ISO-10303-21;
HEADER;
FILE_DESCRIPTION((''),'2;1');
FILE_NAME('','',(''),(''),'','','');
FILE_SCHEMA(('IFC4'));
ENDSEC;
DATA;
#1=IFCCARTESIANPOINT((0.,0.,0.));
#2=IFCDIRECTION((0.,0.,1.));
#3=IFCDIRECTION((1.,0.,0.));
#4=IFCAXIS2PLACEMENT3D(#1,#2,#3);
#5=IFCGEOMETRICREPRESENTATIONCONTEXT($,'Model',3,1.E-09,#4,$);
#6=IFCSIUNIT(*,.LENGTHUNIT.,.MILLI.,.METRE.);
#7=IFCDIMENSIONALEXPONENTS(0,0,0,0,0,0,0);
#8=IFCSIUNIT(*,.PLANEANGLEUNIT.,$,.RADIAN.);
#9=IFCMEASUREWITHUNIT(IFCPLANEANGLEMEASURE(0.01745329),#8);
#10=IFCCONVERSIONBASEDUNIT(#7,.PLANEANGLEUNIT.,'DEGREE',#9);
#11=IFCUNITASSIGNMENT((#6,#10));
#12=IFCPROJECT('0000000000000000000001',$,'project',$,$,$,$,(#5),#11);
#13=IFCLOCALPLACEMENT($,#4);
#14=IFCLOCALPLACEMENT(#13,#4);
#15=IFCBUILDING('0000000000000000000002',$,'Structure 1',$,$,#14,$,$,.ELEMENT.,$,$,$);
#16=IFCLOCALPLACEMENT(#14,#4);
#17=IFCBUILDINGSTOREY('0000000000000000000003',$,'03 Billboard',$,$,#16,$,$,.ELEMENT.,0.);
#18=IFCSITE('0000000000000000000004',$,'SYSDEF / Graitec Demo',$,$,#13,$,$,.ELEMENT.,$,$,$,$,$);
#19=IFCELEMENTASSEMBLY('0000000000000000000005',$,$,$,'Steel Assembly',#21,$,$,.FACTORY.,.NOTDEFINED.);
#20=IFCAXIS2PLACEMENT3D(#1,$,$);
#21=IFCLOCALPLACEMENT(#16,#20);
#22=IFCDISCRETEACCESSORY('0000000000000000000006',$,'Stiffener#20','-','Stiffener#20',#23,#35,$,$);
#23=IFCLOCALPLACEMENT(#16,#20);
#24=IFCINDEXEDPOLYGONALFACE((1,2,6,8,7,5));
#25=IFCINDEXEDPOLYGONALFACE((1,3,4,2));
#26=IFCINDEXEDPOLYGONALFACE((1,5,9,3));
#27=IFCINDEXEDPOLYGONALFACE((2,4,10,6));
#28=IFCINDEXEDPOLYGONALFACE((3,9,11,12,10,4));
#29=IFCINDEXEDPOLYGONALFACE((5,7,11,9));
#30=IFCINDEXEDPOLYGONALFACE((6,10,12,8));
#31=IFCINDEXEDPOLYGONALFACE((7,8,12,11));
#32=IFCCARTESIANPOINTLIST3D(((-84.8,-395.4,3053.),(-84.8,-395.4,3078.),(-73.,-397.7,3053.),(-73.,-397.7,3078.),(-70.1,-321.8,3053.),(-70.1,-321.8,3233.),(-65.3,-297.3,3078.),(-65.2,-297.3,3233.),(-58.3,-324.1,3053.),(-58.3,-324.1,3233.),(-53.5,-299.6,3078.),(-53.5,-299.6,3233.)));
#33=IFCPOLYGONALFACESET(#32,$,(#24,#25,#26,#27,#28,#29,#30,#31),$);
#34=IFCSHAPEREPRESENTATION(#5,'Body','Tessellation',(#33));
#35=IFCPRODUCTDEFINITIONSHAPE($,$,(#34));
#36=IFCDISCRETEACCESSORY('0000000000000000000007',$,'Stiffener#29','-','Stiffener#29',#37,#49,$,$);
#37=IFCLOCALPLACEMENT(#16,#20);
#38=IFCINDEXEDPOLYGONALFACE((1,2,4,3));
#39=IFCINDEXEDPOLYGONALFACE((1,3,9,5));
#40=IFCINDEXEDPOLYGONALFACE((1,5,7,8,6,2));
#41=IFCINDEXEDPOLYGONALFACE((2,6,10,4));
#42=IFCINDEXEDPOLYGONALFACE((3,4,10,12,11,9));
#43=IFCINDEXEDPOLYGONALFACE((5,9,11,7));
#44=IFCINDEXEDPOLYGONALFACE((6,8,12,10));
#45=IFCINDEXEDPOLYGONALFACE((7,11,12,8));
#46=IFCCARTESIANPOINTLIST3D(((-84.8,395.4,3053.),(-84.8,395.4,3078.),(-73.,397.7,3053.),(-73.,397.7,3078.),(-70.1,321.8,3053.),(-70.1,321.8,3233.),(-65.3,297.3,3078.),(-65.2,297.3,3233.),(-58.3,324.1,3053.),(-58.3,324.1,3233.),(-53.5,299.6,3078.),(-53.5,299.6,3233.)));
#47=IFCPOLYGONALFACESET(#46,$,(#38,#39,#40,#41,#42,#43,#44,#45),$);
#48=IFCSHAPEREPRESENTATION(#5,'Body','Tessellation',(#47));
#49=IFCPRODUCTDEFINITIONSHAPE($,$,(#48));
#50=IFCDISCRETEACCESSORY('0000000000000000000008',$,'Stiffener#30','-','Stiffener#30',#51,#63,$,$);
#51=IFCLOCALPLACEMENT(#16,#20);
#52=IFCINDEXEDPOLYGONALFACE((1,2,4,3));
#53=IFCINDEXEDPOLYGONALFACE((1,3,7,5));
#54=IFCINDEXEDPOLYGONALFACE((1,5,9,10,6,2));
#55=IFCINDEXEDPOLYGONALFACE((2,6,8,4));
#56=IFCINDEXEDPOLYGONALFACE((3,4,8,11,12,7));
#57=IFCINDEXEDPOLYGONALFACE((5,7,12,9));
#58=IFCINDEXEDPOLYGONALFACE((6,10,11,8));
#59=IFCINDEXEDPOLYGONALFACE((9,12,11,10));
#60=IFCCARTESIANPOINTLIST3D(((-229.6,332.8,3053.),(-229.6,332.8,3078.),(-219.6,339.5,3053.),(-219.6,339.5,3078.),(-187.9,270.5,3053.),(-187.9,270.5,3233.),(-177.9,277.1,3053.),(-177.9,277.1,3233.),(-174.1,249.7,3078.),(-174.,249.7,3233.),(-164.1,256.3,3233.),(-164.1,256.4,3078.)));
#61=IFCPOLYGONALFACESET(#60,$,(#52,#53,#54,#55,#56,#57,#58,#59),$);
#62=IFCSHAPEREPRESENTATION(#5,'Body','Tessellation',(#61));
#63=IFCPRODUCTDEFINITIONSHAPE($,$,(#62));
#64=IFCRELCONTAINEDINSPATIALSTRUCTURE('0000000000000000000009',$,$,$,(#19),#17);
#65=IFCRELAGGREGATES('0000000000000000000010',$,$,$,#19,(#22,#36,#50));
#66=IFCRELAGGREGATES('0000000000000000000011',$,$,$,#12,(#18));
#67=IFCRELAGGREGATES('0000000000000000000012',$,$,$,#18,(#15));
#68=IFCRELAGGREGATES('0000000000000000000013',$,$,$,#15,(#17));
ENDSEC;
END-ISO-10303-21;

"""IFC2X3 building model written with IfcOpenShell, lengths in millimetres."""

from ifc_helpers import new_model, entity, si_unit, converted_unit, frame, origin, origin_with_axes, place, context, project, spatial, polyline, outline, extrude, element, aggregate, save


model = new_model("IFC2X3")

# Units and contexts
model_context = context("Model", 3, precision=1e-09, world=origin_with_axes())
ifc_project = project(units=[si_unit("LENGTHUNIT", "METRE", prefix="MILLI"), converted_unit("PLANEANGLEUNIT", "DEGREE", entity("IfcPlaneAngleMeasure", 0.01745329), si_unit("PLANEANGLEUNIT", "RADIAN"), dimensions=[0, 0, 0, 0, 0, 0, 0])], contexts=[model_context])

# Site, building, storey
site_placement = place(None, origin_with_axes())
site = spatial("IfcSite", under=ifc_project, at=site_placement, Name="SYSDEF / Graitec Demo", CompositionType="ELEMENT")
building_placement = place(site_placement, origin_with_axes())
building = spatial("IfcBuilding", under=site, at=building_placement, Name="Structure 1", CompositionType="ELEMENT")
storey_placement = place(building_placement, origin_with_axes())
storey = spatial("IfcBuildingStorey", under=building, at=storey_placement, Name="03 Billboard", CompositionType="ELEMENT", Elevation=0.0)

# Element assembly, discrete accessories, openings
assembly_placement = place(None, frame((-4406.3, 0.0, 3558.0), z_axis=(-1.0, 0.0, 0.0), x_axis=(0.0, -1.0, 0.0)))
assembly = element("IfcElementAssembly", 1, at=assembly_placement, inside=storey, ObjectType="Steel Assembly", AssemblyPlace="FACTORY", PredefinedType="NOTDEFINED")
discrete_accessory_1_placement = place(assembly_placement, frame((297.3, -505.0, -4341.1), z_axis=(0.19509, 0.0, -0.980785), x_axis=(0.0, 1.0, 0.0)))
discrete_accessory_1 = element("IfcDiscreteAccessory", 2, at=discrete_accessory_1_placement, Name="Stiffener#20", Description="-", ObjectType="Stiffener#20", context=model_context, shape_type="SweptSolid", body=[
    extrude(outline(polyline([(0.0, 0.0), (180.0, 0.0), (180.0, 100.0), (0.0, 100.0), (0.0, 0.0)])), origin_with_axes(), (0.0, 0.0, 1.0), 12.0),
])
opening_1_placement = place(discrete_accessory_1_placement, frame((0.0, 0.0, 0.0), z_axis=(0.0, 0.0, 1.0), x_axis=(1.0, 0.0, 0.0)))
element("IfcOpeningElement", 3, at=opening_1_placement, cuts=discrete_accessory_1, ObjectType="Opening", context=model_context, shape_type="SweptSolid", body=[
    extrude(outline(polyline([(180.0, 100.0), (25.0, 100.0), (180.0, 25.0), (180.0, 100.0)])), origin(), (0.0, 0.0, 1.0), 12.0),
])
opening_2_placement = place(discrete_accessory_1_placement, frame((0.0, 0.0, 0.0), z_axis=(0.0, 0.0, 1.0), x_axis=(1.0, 0.0, 0.0)))
element("IfcOpeningElement", 4, at=opening_2_placement, cuts=discrete_accessory_1, ObjectType="Opening", context=model_context, shape_type="SweptSolid", body=[
    extrude(outline(polyline([(0.0, 0.0), (25.0, 0.0), (0.0, 25.0), (0.0, 0.0)])), origin(), (0.0, 0.0, 1.0), 12.0),
])
discrete_accessory_2_placement = place(assembly_placement, frame((-299.6, -505.0, -4352.9), z_axis=(0.19509, 0.0, 0.980785), x_axis=(0.0, 1.0, 0.0)))
discrete_accessory_2 = element("IfcDiscreteAccessory", 5, at=discrete_accessory_2_placement, Name="Stiffener#29", Description="-", ObjectType="Stiffener#29", context=model_context, shape_type="SweptSolid", body=[
    extrude(outline(polyline([(0.0, 0.0), (180.0, 0.0), (180.0, 100.0), (0.0, 100.0), (0.0, 0.0)])), origin_with_axes(), (0.0, 0.0, 1.0), 12.0),
])
opening_3_placement = place(discrete_accessory_2_placement, frame((0.0, 0.0, 0.0), z_axis=(0.0, 0.0, 1.0), x_axis=(1.0, 0.0, 0.0)))
element("IfcOpeningElement", 6, at=opening_3_placement, cuts=discrete_accessory_2, ObjectType="Opening", context=model_context, shape_type="SweptSolid", body=[
    extrude(outline(polyline([(180.0, 100.0), (25.0, 100.0), (180.0, 25.0), (180.0, 100.0)])), origin(), (0.0, 0.0, 1.0), 12.0),
])
opening_4_placement = place(discrete_accessory_2_placement, frame((0.0, 0.0, 0.0), z_axis=(0.0, 0.0, 1.0), x_axis=(1.0, 0.0, 0.0)))
element("IfcOpeningElement", 7, at=opening_4_placement, cuts=discrete_accessory_2, ObjectType="Opening", context=model_context, shape_type="SweptSolid", body=[
    extrude(outline(polyline([(0.0, 0.0), (25.0, 0.0), (0.0, 25.0), (0.0, 0.0)])), origin(), (0.0, 0.0, 1.0), 12.0),
])
discrete_accessory_3_placement = place(assembly_placement, frame((-256.3, -505.0, -4242.3), z_axis=(0.55557, 0.0, 0.83147), x_axis=(0.0, 1.0, 0.0)))
discrete_accessory_3 = element("IfcDiscreteAccessory", 8, at=discrete_accessory_3_placement, Name="Stiffener#30", Description="-", ObjectType="Stiffener#30", context=model_context, shape_type="SweptSolid", body=[
    extrude(outline(polyline([(0.0, 0.0), (180.0, 0.0), (180.0, 100.0), (0.0, 100.0), (0.0, 0.0)])), origin_with_axes(), (0.0, 0.0, 1.0), 12.0),
])
opening_5_placement = place(discrete_accessory_3_placement, frame((0.0, 0.0, 0.0), z_axis=(0.0, 0.0, 1.0), x_axis=(1.0, 0.0, 0.0)))
element("IfcOpeningElement", 9, at=opening_5_placement, cuts=discrete_accessory_3, ObjectType="Opening", context=model_context, shape_type="SweptSolid", body=[
    extrude(outline(polyline([(180.0, 100.0), (25.0, 100.0), (180.0, 25.0), (180.0, 100.0)])), origin(), (0.0, 0.0, 1.0), 12.0),
])
opening_6_placement = place(discrete_accessory_3_placement, frame((0.0, 0.0, 0.0), z_axis=(0.0, 0.0, 1.0), x_axis=(1.0, 0.0, 0.0)))
element("IfcOpeningElement", 10, at=opening_6_placement, cuts=discrete_accessory_3, ObjectType="Opening", context=model_context, shape_type="SweptSolid", body=[
    extrude(outline(polyline([(0.0, 0.0), (25.0, 0.0), (0.0, 25.0), (0.0, 0.0)])), origin(), (0.0, 0.0, 1.0), 12.0),
])
aggregate(assembly, [discrete_accessory_1, discrete_accessory_2, discrete_accessory_3])

save(model, "model.ifc")
